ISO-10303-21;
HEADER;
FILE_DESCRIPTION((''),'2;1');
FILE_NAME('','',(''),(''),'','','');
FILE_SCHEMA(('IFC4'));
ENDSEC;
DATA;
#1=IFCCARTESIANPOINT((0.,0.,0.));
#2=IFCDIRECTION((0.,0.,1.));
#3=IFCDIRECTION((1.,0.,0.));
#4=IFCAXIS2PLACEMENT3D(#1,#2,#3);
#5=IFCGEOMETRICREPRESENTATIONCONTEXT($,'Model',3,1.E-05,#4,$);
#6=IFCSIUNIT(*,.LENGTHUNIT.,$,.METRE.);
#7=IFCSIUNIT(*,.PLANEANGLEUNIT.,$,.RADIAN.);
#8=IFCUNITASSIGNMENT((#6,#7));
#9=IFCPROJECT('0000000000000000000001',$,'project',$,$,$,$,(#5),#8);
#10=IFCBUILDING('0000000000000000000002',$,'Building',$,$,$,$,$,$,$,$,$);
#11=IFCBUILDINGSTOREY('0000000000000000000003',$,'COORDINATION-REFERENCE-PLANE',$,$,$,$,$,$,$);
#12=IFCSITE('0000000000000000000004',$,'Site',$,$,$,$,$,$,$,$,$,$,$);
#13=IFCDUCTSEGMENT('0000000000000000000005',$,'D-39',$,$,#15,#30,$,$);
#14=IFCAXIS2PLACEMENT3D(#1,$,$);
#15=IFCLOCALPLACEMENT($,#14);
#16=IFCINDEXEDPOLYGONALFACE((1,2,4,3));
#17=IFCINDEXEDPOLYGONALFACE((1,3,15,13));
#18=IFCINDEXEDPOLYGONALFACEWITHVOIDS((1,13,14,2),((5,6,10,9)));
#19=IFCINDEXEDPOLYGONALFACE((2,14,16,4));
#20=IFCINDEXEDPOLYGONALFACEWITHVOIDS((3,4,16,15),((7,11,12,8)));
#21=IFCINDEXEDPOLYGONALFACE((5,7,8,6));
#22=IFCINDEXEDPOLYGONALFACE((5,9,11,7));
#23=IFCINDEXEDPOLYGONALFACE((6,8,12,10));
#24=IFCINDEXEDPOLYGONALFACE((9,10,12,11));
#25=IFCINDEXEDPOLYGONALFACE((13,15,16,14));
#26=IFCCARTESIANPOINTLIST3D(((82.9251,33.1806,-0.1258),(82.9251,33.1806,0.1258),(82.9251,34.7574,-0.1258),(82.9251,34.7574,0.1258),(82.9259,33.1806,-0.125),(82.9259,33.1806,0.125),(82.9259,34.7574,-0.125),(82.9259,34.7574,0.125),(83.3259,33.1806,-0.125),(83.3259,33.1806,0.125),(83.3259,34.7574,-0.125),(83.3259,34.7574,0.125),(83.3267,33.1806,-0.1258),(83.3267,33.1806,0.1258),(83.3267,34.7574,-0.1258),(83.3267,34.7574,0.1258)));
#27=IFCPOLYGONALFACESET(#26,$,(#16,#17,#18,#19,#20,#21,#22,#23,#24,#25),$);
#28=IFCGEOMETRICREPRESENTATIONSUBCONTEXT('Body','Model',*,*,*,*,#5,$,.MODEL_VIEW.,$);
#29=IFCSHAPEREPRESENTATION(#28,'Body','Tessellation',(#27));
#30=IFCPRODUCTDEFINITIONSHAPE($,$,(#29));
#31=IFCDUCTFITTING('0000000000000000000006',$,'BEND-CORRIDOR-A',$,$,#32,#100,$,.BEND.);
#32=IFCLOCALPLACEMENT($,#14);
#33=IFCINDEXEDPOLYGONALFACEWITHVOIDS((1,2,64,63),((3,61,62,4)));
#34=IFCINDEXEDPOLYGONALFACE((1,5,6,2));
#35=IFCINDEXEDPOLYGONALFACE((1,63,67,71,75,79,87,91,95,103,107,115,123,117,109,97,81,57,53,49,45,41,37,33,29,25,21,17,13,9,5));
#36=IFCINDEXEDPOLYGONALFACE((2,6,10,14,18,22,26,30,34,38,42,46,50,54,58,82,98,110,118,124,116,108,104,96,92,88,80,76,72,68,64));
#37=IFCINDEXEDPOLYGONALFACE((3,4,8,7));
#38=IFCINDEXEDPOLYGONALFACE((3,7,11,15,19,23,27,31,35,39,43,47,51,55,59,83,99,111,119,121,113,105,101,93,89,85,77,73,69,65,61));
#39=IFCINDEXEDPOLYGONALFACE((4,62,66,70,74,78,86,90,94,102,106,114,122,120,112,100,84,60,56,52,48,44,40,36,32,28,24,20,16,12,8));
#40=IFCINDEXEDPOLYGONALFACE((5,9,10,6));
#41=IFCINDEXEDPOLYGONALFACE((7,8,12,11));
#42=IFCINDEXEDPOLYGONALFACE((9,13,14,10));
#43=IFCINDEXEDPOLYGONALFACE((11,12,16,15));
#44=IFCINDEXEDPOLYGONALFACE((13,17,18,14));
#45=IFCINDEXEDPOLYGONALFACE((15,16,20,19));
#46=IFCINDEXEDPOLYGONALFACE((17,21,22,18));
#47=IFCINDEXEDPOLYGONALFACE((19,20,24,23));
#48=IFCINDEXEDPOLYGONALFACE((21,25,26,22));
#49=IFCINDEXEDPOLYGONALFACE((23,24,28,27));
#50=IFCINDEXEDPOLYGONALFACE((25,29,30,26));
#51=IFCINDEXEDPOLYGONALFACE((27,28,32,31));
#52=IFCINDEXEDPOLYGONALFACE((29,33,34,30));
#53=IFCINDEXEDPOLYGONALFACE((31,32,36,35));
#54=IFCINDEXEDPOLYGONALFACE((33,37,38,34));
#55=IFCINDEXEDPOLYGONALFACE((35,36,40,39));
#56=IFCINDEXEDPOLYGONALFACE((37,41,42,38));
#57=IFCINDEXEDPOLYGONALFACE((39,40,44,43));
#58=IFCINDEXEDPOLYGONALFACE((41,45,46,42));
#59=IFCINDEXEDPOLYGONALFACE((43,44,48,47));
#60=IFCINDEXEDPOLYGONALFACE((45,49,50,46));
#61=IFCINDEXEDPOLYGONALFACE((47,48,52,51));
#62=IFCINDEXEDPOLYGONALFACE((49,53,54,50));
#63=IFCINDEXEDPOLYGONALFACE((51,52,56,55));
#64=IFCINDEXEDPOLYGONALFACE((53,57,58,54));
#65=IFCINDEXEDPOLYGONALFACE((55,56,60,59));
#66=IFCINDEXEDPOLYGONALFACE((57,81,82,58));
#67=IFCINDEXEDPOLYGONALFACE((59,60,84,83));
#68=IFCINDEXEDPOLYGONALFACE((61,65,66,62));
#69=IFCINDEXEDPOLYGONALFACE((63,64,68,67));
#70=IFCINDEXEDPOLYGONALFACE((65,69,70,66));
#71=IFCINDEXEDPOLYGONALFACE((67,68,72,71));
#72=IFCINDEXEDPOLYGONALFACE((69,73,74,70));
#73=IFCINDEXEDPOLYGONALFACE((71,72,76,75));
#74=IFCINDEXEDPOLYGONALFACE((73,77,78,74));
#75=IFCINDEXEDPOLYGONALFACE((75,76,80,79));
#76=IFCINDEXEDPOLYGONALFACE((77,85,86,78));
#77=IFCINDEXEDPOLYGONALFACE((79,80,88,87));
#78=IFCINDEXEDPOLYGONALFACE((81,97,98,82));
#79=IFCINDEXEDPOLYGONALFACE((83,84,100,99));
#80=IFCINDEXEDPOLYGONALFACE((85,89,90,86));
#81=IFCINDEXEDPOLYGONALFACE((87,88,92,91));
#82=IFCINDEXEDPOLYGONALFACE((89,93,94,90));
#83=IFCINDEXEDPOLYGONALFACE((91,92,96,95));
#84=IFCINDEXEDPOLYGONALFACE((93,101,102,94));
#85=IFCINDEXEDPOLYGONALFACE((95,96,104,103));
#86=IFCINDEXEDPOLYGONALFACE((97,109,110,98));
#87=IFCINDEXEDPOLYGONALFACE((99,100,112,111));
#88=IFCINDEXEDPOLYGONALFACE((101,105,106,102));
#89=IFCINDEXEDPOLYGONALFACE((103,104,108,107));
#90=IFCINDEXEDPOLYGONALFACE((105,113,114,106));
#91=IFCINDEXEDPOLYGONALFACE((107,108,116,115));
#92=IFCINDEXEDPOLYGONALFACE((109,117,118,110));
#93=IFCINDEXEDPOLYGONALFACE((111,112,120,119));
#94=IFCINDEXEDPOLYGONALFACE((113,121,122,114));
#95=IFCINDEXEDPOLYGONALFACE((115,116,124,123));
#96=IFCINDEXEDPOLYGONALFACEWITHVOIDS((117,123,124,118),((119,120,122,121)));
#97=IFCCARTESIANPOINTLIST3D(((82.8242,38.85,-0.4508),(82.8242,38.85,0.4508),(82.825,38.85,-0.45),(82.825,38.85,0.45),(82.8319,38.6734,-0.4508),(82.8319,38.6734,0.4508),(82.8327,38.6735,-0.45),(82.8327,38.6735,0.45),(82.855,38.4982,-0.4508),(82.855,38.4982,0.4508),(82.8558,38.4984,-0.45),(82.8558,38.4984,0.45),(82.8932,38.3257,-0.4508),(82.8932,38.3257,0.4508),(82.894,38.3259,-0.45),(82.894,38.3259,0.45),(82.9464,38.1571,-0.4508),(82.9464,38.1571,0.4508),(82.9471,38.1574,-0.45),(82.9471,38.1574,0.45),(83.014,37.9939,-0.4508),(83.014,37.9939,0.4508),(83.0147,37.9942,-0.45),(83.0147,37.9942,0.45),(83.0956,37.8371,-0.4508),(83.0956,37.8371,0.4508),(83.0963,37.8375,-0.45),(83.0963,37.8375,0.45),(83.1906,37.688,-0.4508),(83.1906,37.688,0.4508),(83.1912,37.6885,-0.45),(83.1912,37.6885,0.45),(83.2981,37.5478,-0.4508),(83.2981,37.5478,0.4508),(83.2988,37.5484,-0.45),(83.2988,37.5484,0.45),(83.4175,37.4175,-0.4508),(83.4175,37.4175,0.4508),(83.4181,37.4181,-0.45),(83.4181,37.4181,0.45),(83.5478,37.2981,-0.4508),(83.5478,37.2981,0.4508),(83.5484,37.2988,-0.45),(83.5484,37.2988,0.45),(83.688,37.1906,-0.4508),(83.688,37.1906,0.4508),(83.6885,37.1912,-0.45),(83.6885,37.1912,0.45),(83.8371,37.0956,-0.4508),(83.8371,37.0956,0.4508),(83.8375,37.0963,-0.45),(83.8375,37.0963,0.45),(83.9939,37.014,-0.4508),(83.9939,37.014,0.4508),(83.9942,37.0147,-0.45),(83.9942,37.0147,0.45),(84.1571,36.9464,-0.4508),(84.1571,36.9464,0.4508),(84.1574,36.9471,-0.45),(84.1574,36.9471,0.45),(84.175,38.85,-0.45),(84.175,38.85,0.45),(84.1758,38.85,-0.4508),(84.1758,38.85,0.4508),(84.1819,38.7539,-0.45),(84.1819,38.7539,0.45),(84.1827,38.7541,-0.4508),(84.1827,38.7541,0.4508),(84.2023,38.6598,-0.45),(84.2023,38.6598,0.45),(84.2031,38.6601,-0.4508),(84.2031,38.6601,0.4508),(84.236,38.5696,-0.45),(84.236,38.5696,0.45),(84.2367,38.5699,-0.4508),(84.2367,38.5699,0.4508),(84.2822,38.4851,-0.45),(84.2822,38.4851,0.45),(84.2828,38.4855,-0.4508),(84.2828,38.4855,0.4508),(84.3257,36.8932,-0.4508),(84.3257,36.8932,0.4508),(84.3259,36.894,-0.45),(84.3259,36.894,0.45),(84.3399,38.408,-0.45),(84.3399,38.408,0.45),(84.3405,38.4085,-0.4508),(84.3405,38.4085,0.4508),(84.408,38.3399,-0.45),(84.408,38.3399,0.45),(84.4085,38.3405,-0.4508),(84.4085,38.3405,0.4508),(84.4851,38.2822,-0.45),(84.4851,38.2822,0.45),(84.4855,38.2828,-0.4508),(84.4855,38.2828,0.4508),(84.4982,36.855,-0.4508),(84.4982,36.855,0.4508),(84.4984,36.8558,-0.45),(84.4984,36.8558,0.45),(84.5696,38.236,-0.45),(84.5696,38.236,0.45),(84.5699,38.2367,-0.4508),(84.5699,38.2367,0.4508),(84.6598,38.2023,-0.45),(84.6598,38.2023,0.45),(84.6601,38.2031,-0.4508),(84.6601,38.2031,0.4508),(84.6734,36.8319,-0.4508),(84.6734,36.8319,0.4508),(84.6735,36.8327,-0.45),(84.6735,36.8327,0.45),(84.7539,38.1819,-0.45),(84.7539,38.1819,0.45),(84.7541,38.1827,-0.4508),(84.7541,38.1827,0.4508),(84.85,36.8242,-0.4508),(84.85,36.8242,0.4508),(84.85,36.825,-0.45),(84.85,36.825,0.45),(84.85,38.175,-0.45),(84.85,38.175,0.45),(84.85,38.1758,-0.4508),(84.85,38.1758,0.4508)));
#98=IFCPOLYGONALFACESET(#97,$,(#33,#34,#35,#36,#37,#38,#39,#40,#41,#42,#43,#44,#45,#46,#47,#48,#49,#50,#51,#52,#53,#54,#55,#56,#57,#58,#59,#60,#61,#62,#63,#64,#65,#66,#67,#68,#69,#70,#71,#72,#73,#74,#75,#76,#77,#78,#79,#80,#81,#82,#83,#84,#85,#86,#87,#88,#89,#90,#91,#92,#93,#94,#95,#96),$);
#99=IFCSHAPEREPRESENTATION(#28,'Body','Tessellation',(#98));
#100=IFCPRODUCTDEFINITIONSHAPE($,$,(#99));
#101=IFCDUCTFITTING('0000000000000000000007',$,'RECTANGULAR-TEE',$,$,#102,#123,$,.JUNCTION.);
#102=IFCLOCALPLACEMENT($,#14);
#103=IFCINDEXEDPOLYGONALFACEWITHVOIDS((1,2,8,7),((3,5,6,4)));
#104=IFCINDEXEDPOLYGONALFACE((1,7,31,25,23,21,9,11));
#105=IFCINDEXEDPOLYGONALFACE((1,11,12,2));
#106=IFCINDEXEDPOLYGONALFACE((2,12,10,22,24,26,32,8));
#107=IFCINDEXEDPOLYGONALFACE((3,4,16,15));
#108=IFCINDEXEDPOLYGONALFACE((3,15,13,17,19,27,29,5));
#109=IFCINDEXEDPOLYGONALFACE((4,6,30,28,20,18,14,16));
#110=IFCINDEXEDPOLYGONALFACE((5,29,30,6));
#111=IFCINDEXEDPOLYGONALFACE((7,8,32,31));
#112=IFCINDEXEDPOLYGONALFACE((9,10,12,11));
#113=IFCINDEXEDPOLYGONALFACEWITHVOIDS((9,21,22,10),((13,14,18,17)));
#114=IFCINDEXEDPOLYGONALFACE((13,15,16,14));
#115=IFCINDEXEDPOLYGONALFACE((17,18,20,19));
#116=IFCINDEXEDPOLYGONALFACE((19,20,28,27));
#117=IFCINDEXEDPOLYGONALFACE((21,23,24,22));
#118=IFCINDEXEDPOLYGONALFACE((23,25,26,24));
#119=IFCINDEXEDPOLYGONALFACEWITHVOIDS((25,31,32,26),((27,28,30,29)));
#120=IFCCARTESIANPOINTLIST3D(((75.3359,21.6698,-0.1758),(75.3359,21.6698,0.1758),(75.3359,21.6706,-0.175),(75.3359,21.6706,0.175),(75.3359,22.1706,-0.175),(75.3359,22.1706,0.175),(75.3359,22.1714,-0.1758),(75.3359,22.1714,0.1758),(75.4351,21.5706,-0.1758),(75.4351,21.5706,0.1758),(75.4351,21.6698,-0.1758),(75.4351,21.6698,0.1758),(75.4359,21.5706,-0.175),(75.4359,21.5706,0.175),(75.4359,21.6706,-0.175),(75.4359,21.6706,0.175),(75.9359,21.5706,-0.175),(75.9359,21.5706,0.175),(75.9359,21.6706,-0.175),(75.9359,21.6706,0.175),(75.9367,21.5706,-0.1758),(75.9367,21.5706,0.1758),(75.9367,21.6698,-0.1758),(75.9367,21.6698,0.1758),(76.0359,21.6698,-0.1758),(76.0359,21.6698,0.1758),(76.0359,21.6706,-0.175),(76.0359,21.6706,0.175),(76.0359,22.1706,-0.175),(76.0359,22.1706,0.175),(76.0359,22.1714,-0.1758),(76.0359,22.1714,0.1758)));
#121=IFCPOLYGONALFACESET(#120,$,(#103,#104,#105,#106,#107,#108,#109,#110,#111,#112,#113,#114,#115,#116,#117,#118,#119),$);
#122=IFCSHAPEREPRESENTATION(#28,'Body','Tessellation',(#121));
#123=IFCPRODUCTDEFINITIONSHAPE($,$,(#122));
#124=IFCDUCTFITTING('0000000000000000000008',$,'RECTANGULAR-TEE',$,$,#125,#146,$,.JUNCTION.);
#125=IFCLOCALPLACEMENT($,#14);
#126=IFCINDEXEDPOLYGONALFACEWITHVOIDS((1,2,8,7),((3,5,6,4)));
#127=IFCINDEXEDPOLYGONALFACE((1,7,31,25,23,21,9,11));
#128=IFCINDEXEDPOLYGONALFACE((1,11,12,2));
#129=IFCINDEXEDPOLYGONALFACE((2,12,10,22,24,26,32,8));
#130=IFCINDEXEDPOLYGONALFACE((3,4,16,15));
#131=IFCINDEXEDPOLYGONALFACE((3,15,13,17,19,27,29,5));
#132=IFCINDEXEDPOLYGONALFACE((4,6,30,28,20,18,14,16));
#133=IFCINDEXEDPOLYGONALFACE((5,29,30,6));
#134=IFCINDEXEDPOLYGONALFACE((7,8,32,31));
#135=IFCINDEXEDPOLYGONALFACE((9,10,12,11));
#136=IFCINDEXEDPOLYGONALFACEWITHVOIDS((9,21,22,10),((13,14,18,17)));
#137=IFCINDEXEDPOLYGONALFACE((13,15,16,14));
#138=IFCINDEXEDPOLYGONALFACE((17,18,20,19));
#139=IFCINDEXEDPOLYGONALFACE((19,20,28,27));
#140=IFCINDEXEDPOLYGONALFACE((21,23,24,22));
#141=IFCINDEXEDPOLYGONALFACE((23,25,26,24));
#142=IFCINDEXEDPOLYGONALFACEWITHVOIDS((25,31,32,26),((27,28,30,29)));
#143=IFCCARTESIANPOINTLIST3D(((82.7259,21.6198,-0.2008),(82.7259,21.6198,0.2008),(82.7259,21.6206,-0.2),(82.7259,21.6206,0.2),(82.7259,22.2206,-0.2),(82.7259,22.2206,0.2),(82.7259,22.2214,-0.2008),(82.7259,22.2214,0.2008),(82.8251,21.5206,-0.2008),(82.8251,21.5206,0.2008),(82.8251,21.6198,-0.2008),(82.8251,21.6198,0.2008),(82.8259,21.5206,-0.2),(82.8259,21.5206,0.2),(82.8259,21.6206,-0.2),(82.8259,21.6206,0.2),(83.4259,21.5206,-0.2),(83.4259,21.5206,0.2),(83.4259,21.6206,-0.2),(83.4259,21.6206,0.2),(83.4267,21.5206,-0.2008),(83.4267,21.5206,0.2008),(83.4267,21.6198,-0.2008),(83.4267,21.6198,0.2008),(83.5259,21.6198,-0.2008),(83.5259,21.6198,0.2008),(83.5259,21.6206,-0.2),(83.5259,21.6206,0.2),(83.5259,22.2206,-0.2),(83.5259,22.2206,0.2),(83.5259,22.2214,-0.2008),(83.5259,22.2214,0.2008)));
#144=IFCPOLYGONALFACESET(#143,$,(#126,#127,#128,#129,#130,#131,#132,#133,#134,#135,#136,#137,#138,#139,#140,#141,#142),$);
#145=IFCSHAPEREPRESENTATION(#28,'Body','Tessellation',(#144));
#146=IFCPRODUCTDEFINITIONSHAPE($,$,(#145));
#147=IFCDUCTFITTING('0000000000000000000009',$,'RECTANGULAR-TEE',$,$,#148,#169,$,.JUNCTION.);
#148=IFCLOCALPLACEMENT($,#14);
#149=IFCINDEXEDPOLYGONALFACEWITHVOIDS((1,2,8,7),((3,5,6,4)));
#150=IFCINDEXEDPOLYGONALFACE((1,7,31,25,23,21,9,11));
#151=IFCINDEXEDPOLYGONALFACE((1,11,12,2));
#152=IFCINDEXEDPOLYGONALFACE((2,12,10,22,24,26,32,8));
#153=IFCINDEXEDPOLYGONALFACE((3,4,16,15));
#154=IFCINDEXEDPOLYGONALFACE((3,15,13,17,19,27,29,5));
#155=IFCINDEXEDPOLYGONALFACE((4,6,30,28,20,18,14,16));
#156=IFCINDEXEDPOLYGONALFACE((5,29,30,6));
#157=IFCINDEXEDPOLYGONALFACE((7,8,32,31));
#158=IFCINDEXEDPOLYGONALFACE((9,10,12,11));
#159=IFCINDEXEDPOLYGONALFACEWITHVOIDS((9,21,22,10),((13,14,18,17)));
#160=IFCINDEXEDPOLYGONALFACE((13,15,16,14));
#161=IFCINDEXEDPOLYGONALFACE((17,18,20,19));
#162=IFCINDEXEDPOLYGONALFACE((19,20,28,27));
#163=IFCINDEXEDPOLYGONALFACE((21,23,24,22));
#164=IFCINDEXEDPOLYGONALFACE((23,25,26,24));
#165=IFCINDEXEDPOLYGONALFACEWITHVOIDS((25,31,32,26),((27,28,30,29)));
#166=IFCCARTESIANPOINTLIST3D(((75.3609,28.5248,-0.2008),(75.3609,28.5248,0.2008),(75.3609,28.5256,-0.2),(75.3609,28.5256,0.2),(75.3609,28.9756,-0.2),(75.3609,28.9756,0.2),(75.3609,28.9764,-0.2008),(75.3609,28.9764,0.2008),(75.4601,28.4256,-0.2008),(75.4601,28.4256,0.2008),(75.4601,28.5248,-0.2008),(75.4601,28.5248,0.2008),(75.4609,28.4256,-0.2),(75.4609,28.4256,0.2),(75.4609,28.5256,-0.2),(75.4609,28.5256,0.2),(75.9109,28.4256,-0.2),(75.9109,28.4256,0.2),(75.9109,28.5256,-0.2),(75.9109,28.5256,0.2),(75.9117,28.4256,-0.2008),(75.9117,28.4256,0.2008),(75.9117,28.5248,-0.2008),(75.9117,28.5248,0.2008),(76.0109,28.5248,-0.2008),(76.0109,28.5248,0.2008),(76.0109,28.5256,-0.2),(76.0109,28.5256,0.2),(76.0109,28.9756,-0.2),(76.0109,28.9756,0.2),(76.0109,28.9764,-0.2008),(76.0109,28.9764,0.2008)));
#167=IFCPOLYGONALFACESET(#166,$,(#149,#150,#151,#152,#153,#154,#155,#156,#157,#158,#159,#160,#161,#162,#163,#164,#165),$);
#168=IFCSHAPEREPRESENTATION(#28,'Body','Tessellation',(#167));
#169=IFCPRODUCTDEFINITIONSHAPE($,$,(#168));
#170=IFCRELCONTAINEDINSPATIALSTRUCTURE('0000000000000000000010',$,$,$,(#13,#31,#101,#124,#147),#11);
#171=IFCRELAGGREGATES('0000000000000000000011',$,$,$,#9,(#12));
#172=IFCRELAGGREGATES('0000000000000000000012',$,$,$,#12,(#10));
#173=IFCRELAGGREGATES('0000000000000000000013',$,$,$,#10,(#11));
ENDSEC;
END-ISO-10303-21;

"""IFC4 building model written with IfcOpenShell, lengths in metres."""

from ifc_helpers import new_model, entity, si_unit, frame, origin, origin_with_axes, place, context, subcontext, project, spatial, rectangle, hollow_rectangle, extrude, boolean, element, save


model = new_model("IFC4")

# Units and contexts
model_context = context("Model", 3, precision=1e-05, world=origin_with_axes())
body_context = subcontext(model_context, "Body", "Model", "MODEL_VIEW")
ifc_project = project(units=[si_unit("LENGTHUNIT", "METRE"), si_unit("PLANEANGLEUNIT", "RADIAN")], contexts=[model_context])

# Site, building, storey
site = spatial("IfcSite", under=ifc_project, Name="Site")
building = spatial("IfcBuilding", under=site, Name="Building")
storey = spatial("IfcBuildingStorey", under=building, Name="COORDINATION-REFERENCE-PLANE")

# Duct segment
duct_segment_1_placement = place(None, frame((83.1259, 33.1806, 0.0), z_axis=(0.0, 1.0, 0.0), x_axis=(1.0, 0.0, 0.0)))
element("IfcDuctSegment", 1, at=duct_segment_1_placement, inside=storey, Name="D-39", context=body_context, shape_type="SweptSolid", body=[
    extrude(hollow_rectangle(XDim=0.4016, YDim=0.2516, WallThickness=0.0008), origin(), (0.0, 0.0, 1.0), 1.5768),
])

# Duct fittings
duct_fitting_1_placement = place(None, frame((84.85, 38.85, 0.0), z_axis=(0.0, 0.0, 1.0), x_axis=(-1.0, 0.0, 0.0)))
cartesian_point_1 = entity("IfcCartesianPoint", [0.0, 0.0, 0.0])
element("IfcDuctFitting", 2, at=duct_fitting_1_placement, inside=storey, Name="BEND-CORRIDOR-A", PredefinedType="BEND", context=body_context, shape_type="SweptSolid", body=[
    entity("IfcRevolvedAreaSolid", entity("IfcRectangleHollowProfileDef", "AREA", None, entity("IfcAxis2Placement2D", entity("IfcCartesianPoint", [1.35, 0.0])), 1.3516, 0.9016, 0.0008), entity("IfcAxis2Placement3D", cartesian_point_1, entity("IfcDirection", [0.0, -1.0, 0.0]), entity("IfcDirection", [1.0, 0.0, 0.0])), entity("IfcAxis1Placement", cartesian_point_1, entity("IfcDirection", [0.0, 1.0, 0.0])), 1.570796),
])
duct_fitting_2_placement = place(None, frame((75.6859, 21.9206, 0.0), z_axis=(-1.0, 0.0, 0.0), x_axis=(0.0, -1.0, 0.0)))
solid_1 = boolean("UNION", extrude(rectangle(XDim=0.5, YDim=0.35), frame((0.0, 0.0, -0.35), z_axis=(0.0, 0.0, 1.0), x_axis=(1.0, 0.0, 0.0)), (0.0, 0.0, 1.0), 0.7), extrude(rectangle(XDim=0.5, YDim=0.35), frame((0.0, 0.0, 0.0), z_axis=(1.0, 0.0, 0.0), x_axis=(0.0, 0.0, -1.0)), (0.0, 0.0, 1.0), 0.35))
element("IfcDuctFitting", 3, at=duct_fitting_2_placement, inside=storey, Name="RECTANGULAR-TEE", PredefinedType="JUNCTION", context=body_context, shape_type="CSG", body=[
    boolean("DIFFERENCE", boolean("UNION", extrude(rectangle(XDim=0.5016, YDim=0.3516), frame((0.0, 0.0, -0.35), z_axis=(0.0, 0.0, 1.0), x_axis=(1.0, 0.0, 0.0)), (0.0, 0.0, 1.0), 0.7), extrude(rectangle(XDim=0.5016, YDim=0.3516), frame((0.0, 0.0, 0.0), z_axis=(1.0, 0.0, 0.0), x_axis=(0.0, 0.0, -1.0)), (0.0, 0.0, 1.0), 0.35)), solid_1),
])
duct_fitting_3_placement = place(None, frame((83.1259, 21.9206, 0.0), z_axis=(-1.0, 0.0, 0.0), x_axis=(0.0, -1.0, 0.0)))
solid_2 = boolean("UNION", extrude(rectangle(XDim=0.6, YDim=0.4), frame((0.0, 0.0, -0.4), z_axis=(0.0, 0.0, 1.0), x_axis=(1.0, 0.0, 0.0)), (0.0, 0.0, 1.0), 0.8), extrude(rectangle(XDim=0.6, YDim=0.4), frame((0.0, 0.0, 0.0), z_axis=(1.0, 0.0, 0.0), x_axis=(0.0, 0.0, -1.0)), (0.0, 0.0, 1.0), 0.4))
element("IfcDuctFitting", 4, at=duct_fitting_3_placement, inside=storey, Name="RECTANGULAR-TEE", PredefinedType="JUNCTION", context=body_context, shape_type="CSG", body=[
    boolean("DIFFERENCE", boolean("UNION", extrude(rectangle(XDim=0.6016, YDim=0.4016), frame((0.0, 0.0, -0.4), z_axis=(0.0, 0.0, 1.0), x_axis=(1.0, 0.0, 0.0)), (0.0, 0.0, 1.0), 0.8), extrude(rectangle(XDim=0.6016, YDim=0.4016), frame((0.0, 0.0, 0.0), z_axis=(1.0, 0.0, 0.0), x_axis=(0.0, 0.0, -1.0)), (0.0, 0.0, 1.0), 0.4)), solid_2),
])
duct_fitting_4_placement = place(None, frame((75.6859, 28.7506, 0.0), z_axis=(-1.0, 0.0, 0.0), x_axis=(0.0, -1.0, 0.0)))
solid_3 = boolean("UNION", extrude(rectangle(XDim=0.45, YDim=0.4), frame((0.0, 0.0, -0.325), z_axis=(0.0, 0.0, 1.0), x_axis=(1.0, 0.0, 0.0)), (0.0, 0.0, 1.0), 0.65), extrude(rectangle(XDim=0.45, YDim=0.4), frame((0.0, 0.0, 0.0), z_axis=(1.0, 0.0, 0.0), x_axis=(0.0, 0.0, -1.0)), (0.0, 0.0, 1.0), 0.325))
element("IfcDuctFitting", 5, at=duct_fitting_4_placement, inside=storey, Name="RECTANGULAR-TEE", PredefinedType="JUNCTION", context=body_context, shape_type="CSG", body=[
    boolean("DIFFERENCE", boolean("UNION", extrude(rectangle(XDim=0.4516, YDim=0.4016), frame((0.0, 0.0, -0.325), z_axis=(0.0, 0.0, 1.0), x_axis=(1.0, 0.0, 0.0)), (0.0, 0.0, 1.0), 0.65), extrude(rectangle(XDim=0.4516, YDim=0.4016), frame((0.0, 0.0, 0.0), z_axis=(1.0, 0.0, 0.0), x_axis=(0.0, 0.0, -1.0)), (0.0, 0.0, 1.0), 0.325)), solid_3),
])

save(model, "model.ifc")
